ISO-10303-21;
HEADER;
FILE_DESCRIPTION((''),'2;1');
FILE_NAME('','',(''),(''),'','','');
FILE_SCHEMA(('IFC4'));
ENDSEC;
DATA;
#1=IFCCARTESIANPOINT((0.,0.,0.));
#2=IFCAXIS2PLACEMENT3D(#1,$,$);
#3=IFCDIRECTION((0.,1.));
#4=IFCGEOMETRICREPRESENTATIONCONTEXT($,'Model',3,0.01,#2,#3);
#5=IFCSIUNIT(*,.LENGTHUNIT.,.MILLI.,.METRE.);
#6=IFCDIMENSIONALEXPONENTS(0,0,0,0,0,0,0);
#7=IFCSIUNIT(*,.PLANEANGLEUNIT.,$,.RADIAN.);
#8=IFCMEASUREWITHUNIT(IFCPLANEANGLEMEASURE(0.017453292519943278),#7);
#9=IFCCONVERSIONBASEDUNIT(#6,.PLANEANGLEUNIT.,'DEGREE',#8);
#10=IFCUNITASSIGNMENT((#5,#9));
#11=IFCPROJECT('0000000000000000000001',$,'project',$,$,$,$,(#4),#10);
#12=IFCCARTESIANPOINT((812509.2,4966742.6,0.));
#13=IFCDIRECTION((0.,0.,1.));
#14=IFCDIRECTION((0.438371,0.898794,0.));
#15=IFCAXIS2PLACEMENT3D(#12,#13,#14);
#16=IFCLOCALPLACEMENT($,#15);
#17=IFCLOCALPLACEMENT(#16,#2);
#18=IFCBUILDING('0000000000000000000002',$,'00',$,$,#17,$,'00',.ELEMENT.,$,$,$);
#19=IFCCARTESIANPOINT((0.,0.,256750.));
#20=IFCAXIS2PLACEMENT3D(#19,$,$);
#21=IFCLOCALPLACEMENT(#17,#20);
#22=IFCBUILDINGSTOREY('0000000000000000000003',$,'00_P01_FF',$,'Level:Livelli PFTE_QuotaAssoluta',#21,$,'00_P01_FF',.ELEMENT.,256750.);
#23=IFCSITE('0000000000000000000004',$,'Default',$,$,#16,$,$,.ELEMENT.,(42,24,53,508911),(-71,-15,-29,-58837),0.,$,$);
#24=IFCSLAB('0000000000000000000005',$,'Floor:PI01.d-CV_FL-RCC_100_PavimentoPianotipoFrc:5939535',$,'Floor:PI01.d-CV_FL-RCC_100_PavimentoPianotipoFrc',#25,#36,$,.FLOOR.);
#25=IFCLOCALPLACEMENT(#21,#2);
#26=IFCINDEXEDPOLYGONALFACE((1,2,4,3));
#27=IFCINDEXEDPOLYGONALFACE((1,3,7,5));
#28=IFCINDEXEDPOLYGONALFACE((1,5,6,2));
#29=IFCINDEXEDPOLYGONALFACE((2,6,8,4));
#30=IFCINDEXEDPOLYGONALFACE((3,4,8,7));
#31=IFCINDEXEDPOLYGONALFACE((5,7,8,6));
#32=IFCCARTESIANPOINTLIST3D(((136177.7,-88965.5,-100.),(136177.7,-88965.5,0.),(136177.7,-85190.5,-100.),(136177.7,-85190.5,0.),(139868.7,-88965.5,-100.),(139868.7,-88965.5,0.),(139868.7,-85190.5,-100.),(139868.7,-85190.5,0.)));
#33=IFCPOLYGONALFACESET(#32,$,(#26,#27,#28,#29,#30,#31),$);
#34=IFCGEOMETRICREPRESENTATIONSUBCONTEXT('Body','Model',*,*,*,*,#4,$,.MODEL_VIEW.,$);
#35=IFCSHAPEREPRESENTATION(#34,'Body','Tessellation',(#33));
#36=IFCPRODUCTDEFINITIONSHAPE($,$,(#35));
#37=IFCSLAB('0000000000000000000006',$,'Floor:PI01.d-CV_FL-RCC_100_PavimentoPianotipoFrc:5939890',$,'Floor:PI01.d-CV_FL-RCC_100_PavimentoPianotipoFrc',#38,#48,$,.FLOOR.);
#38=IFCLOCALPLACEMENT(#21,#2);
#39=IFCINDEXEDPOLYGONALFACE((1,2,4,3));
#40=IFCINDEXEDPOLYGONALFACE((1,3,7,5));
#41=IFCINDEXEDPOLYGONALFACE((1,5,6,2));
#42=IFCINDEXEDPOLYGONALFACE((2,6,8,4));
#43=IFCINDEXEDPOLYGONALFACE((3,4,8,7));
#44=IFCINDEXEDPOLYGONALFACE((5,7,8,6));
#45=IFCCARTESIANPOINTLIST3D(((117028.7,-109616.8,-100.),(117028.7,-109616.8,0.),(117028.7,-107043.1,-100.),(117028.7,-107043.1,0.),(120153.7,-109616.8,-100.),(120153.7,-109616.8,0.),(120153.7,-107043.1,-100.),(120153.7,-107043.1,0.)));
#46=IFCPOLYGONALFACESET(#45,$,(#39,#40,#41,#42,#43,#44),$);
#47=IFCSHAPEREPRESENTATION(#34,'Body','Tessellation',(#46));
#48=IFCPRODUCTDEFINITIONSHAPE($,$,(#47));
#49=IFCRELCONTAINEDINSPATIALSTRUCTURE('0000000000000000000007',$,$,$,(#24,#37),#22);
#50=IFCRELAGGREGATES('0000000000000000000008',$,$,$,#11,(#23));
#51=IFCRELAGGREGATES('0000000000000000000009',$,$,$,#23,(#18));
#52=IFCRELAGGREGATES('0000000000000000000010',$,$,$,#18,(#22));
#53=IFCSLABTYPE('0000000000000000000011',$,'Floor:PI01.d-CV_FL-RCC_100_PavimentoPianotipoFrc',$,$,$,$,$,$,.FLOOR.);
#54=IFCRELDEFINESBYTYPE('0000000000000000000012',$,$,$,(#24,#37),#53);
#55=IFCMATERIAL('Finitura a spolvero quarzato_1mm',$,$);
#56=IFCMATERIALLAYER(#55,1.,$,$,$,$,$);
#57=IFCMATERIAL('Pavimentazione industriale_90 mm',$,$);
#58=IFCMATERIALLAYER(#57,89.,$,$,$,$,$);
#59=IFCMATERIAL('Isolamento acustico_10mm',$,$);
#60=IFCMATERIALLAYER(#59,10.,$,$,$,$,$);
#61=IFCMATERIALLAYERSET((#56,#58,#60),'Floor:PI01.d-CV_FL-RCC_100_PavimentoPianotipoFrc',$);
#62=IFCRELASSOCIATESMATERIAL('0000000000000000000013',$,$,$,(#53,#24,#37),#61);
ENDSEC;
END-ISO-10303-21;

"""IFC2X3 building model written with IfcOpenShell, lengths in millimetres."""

from ifc_helpers import new_model, entity, si_unit, converted_unit, direction, frame, frame_2d, origin, origin_2d_with_axis, place, context, subcontext, project, spatial, rectangle, extrude, material, layer, layer_set, layer_usage, type_object, element, save


model = new_model("IFC2X3")

# Units and contexts
model_context = context("Model", 3, precision=0.01, world=origin(), true_north=direction((0.0, 1.0)))
body_context = subcontext(model_context, "Body", "Model", "MODEL_VIEW")
ifc_project = project(units=[si_unit("LENGTHUNIT", "METRE", prefix="MILLI"), converted_unit("PLANEANGLEUNIT", "DEGREE", entity("IfcPlaneAngleMeasure", 0.017453292519943278), si_unit("PLANEANGLEUNIT", "RADIAN"), dimensions=[0, 0, 0, 0, 0, 0, 0])], contexts=[model_context])

# Site, building, storey
site_placement = place(None, frame((812509.2, 4966742.6, 0.0), z_axis=(0.0, 0.0, 1.0), x_axis=(0.438371, 0.898794, 0.0)))
site = spatial("IfcSite", under=ifc_project, at=site_placement, Name="Default", CompositionType="ELEMENT", RefLatitude=(42, 24, 53, 508911), RefLongitude=(-71, -15, -29, -58837), RefElevation=0.0)
building_placement = place(site_placement, origin())
building = spatial("IfcBuilding", under=site, at=building_placement, Name="00", LongName="00", CompositionType="ELEMENT")
storey_placement = place(building_placement, frame((0.0, 0.0, 256750.0)))
storey = spatial("IfcBuildingStorey", under=building, at=storey_placement, Name="00_P01_FF", ObjectType="Level:Livelli PFTE_QuotaAssoluta", LongName="00_P01_FF", CompositionType="ELEMENT", Elevation=256750.0)

# Shared definitions
ifc_material_1 = material(Name="Isolamento acustico_10mm")

# Slabs
ifc_material_2 = material(Name="Finitura a spolvero quarzato_1mm")
ifc_layer_1 = layer(ifc_material_2, 1.0)
ifc_material_3 = material(Name="Pavimentazione industriale_90 mm")
ifc_layer_2 = layer(ifc_material_3, 89.0)
ifc_layer_3 = layer(ifc_material_1, 10.0)
ifc_layer_set_1 = layer_set([ifc_layer_1, ifc_layer_2, ifc_layer_3], Name="Floor:PI01.d-CV_FL-RCC_100_PavimentoPianotipoFrc")
ifc_layer_usage_1 = layer_usage(ifc_layer_set_1, "AXIS3", "POSITIVE", 0.0)
slab_type_1 = type_object("IfcSlabType", Name="Floor:PI01.d-CV_FL-RCC_100_PavimentoPianotipoFrc", PredefinedType="FLOOR", material=ifc_layer_set_1)
slab_1_placement = place(storey_placement, origin())
element("IfcSlab", 1, at=slab_1_placement, inside=storey, type_object=slab_type_1, material=ifc_layer_usage_1, Name="Floor:PI01.d-CV_FL-RCC_100_PavimentoPianotipoFrc:5939535", ObjectType="Floor:PI01.d-CV_FL-RCC_100_PavimentoPianotipoFrc", PredefinedType="FLOOR", context=body_context, shape_type="SweptSolid", body=[
    extrude(rectangle(XDim=3775.0, YDim=3691.0, at=frame_2d((0.0, 0.0), x_axis=(1.0, 0.0))), frame((138023.2, -87078.0, 0.0), z_axis=(0.0, 0.0, -1.0), x_axis=(0.0, 1.0, 0.0)), (0.0, 0.0, 1.0), 100.0),
])
ifc_layer_usage_2 = layer_usage(ifc_layer_set_1, "AXIS3", "POSITIVE", 0.0)
slab_2_placement = place(storey_placement, origin())
element("IfcSlab", 2, at=slab_2_placement, inside=storey, type_object=slab_type_1, material=ifc_layer_usage_2, Name="Floor:PI01.d-CV_FL-RCC_100_PavimentoPianotipoFrc:5939890", ObjectType="Floor:PI01.d-CV_FL-RCC_100_PavimentoPianotipoFrc", PredefinedType="FLOOR", context=body_context, shape_type="SweptSolid", body=[
    extrude(rectangle(XDim=2573.7, YDim=3125.0, at=origin_2d_with_axis()), frame((118591.2, -108329.9, 0.0), z_axis=(0.0, 0.0, -1.0), x_axis=(0.0, 1.0, 0.0)), (0.0, 0.0, 1.0), 100.0),
])

save(model, "model.ifc")
